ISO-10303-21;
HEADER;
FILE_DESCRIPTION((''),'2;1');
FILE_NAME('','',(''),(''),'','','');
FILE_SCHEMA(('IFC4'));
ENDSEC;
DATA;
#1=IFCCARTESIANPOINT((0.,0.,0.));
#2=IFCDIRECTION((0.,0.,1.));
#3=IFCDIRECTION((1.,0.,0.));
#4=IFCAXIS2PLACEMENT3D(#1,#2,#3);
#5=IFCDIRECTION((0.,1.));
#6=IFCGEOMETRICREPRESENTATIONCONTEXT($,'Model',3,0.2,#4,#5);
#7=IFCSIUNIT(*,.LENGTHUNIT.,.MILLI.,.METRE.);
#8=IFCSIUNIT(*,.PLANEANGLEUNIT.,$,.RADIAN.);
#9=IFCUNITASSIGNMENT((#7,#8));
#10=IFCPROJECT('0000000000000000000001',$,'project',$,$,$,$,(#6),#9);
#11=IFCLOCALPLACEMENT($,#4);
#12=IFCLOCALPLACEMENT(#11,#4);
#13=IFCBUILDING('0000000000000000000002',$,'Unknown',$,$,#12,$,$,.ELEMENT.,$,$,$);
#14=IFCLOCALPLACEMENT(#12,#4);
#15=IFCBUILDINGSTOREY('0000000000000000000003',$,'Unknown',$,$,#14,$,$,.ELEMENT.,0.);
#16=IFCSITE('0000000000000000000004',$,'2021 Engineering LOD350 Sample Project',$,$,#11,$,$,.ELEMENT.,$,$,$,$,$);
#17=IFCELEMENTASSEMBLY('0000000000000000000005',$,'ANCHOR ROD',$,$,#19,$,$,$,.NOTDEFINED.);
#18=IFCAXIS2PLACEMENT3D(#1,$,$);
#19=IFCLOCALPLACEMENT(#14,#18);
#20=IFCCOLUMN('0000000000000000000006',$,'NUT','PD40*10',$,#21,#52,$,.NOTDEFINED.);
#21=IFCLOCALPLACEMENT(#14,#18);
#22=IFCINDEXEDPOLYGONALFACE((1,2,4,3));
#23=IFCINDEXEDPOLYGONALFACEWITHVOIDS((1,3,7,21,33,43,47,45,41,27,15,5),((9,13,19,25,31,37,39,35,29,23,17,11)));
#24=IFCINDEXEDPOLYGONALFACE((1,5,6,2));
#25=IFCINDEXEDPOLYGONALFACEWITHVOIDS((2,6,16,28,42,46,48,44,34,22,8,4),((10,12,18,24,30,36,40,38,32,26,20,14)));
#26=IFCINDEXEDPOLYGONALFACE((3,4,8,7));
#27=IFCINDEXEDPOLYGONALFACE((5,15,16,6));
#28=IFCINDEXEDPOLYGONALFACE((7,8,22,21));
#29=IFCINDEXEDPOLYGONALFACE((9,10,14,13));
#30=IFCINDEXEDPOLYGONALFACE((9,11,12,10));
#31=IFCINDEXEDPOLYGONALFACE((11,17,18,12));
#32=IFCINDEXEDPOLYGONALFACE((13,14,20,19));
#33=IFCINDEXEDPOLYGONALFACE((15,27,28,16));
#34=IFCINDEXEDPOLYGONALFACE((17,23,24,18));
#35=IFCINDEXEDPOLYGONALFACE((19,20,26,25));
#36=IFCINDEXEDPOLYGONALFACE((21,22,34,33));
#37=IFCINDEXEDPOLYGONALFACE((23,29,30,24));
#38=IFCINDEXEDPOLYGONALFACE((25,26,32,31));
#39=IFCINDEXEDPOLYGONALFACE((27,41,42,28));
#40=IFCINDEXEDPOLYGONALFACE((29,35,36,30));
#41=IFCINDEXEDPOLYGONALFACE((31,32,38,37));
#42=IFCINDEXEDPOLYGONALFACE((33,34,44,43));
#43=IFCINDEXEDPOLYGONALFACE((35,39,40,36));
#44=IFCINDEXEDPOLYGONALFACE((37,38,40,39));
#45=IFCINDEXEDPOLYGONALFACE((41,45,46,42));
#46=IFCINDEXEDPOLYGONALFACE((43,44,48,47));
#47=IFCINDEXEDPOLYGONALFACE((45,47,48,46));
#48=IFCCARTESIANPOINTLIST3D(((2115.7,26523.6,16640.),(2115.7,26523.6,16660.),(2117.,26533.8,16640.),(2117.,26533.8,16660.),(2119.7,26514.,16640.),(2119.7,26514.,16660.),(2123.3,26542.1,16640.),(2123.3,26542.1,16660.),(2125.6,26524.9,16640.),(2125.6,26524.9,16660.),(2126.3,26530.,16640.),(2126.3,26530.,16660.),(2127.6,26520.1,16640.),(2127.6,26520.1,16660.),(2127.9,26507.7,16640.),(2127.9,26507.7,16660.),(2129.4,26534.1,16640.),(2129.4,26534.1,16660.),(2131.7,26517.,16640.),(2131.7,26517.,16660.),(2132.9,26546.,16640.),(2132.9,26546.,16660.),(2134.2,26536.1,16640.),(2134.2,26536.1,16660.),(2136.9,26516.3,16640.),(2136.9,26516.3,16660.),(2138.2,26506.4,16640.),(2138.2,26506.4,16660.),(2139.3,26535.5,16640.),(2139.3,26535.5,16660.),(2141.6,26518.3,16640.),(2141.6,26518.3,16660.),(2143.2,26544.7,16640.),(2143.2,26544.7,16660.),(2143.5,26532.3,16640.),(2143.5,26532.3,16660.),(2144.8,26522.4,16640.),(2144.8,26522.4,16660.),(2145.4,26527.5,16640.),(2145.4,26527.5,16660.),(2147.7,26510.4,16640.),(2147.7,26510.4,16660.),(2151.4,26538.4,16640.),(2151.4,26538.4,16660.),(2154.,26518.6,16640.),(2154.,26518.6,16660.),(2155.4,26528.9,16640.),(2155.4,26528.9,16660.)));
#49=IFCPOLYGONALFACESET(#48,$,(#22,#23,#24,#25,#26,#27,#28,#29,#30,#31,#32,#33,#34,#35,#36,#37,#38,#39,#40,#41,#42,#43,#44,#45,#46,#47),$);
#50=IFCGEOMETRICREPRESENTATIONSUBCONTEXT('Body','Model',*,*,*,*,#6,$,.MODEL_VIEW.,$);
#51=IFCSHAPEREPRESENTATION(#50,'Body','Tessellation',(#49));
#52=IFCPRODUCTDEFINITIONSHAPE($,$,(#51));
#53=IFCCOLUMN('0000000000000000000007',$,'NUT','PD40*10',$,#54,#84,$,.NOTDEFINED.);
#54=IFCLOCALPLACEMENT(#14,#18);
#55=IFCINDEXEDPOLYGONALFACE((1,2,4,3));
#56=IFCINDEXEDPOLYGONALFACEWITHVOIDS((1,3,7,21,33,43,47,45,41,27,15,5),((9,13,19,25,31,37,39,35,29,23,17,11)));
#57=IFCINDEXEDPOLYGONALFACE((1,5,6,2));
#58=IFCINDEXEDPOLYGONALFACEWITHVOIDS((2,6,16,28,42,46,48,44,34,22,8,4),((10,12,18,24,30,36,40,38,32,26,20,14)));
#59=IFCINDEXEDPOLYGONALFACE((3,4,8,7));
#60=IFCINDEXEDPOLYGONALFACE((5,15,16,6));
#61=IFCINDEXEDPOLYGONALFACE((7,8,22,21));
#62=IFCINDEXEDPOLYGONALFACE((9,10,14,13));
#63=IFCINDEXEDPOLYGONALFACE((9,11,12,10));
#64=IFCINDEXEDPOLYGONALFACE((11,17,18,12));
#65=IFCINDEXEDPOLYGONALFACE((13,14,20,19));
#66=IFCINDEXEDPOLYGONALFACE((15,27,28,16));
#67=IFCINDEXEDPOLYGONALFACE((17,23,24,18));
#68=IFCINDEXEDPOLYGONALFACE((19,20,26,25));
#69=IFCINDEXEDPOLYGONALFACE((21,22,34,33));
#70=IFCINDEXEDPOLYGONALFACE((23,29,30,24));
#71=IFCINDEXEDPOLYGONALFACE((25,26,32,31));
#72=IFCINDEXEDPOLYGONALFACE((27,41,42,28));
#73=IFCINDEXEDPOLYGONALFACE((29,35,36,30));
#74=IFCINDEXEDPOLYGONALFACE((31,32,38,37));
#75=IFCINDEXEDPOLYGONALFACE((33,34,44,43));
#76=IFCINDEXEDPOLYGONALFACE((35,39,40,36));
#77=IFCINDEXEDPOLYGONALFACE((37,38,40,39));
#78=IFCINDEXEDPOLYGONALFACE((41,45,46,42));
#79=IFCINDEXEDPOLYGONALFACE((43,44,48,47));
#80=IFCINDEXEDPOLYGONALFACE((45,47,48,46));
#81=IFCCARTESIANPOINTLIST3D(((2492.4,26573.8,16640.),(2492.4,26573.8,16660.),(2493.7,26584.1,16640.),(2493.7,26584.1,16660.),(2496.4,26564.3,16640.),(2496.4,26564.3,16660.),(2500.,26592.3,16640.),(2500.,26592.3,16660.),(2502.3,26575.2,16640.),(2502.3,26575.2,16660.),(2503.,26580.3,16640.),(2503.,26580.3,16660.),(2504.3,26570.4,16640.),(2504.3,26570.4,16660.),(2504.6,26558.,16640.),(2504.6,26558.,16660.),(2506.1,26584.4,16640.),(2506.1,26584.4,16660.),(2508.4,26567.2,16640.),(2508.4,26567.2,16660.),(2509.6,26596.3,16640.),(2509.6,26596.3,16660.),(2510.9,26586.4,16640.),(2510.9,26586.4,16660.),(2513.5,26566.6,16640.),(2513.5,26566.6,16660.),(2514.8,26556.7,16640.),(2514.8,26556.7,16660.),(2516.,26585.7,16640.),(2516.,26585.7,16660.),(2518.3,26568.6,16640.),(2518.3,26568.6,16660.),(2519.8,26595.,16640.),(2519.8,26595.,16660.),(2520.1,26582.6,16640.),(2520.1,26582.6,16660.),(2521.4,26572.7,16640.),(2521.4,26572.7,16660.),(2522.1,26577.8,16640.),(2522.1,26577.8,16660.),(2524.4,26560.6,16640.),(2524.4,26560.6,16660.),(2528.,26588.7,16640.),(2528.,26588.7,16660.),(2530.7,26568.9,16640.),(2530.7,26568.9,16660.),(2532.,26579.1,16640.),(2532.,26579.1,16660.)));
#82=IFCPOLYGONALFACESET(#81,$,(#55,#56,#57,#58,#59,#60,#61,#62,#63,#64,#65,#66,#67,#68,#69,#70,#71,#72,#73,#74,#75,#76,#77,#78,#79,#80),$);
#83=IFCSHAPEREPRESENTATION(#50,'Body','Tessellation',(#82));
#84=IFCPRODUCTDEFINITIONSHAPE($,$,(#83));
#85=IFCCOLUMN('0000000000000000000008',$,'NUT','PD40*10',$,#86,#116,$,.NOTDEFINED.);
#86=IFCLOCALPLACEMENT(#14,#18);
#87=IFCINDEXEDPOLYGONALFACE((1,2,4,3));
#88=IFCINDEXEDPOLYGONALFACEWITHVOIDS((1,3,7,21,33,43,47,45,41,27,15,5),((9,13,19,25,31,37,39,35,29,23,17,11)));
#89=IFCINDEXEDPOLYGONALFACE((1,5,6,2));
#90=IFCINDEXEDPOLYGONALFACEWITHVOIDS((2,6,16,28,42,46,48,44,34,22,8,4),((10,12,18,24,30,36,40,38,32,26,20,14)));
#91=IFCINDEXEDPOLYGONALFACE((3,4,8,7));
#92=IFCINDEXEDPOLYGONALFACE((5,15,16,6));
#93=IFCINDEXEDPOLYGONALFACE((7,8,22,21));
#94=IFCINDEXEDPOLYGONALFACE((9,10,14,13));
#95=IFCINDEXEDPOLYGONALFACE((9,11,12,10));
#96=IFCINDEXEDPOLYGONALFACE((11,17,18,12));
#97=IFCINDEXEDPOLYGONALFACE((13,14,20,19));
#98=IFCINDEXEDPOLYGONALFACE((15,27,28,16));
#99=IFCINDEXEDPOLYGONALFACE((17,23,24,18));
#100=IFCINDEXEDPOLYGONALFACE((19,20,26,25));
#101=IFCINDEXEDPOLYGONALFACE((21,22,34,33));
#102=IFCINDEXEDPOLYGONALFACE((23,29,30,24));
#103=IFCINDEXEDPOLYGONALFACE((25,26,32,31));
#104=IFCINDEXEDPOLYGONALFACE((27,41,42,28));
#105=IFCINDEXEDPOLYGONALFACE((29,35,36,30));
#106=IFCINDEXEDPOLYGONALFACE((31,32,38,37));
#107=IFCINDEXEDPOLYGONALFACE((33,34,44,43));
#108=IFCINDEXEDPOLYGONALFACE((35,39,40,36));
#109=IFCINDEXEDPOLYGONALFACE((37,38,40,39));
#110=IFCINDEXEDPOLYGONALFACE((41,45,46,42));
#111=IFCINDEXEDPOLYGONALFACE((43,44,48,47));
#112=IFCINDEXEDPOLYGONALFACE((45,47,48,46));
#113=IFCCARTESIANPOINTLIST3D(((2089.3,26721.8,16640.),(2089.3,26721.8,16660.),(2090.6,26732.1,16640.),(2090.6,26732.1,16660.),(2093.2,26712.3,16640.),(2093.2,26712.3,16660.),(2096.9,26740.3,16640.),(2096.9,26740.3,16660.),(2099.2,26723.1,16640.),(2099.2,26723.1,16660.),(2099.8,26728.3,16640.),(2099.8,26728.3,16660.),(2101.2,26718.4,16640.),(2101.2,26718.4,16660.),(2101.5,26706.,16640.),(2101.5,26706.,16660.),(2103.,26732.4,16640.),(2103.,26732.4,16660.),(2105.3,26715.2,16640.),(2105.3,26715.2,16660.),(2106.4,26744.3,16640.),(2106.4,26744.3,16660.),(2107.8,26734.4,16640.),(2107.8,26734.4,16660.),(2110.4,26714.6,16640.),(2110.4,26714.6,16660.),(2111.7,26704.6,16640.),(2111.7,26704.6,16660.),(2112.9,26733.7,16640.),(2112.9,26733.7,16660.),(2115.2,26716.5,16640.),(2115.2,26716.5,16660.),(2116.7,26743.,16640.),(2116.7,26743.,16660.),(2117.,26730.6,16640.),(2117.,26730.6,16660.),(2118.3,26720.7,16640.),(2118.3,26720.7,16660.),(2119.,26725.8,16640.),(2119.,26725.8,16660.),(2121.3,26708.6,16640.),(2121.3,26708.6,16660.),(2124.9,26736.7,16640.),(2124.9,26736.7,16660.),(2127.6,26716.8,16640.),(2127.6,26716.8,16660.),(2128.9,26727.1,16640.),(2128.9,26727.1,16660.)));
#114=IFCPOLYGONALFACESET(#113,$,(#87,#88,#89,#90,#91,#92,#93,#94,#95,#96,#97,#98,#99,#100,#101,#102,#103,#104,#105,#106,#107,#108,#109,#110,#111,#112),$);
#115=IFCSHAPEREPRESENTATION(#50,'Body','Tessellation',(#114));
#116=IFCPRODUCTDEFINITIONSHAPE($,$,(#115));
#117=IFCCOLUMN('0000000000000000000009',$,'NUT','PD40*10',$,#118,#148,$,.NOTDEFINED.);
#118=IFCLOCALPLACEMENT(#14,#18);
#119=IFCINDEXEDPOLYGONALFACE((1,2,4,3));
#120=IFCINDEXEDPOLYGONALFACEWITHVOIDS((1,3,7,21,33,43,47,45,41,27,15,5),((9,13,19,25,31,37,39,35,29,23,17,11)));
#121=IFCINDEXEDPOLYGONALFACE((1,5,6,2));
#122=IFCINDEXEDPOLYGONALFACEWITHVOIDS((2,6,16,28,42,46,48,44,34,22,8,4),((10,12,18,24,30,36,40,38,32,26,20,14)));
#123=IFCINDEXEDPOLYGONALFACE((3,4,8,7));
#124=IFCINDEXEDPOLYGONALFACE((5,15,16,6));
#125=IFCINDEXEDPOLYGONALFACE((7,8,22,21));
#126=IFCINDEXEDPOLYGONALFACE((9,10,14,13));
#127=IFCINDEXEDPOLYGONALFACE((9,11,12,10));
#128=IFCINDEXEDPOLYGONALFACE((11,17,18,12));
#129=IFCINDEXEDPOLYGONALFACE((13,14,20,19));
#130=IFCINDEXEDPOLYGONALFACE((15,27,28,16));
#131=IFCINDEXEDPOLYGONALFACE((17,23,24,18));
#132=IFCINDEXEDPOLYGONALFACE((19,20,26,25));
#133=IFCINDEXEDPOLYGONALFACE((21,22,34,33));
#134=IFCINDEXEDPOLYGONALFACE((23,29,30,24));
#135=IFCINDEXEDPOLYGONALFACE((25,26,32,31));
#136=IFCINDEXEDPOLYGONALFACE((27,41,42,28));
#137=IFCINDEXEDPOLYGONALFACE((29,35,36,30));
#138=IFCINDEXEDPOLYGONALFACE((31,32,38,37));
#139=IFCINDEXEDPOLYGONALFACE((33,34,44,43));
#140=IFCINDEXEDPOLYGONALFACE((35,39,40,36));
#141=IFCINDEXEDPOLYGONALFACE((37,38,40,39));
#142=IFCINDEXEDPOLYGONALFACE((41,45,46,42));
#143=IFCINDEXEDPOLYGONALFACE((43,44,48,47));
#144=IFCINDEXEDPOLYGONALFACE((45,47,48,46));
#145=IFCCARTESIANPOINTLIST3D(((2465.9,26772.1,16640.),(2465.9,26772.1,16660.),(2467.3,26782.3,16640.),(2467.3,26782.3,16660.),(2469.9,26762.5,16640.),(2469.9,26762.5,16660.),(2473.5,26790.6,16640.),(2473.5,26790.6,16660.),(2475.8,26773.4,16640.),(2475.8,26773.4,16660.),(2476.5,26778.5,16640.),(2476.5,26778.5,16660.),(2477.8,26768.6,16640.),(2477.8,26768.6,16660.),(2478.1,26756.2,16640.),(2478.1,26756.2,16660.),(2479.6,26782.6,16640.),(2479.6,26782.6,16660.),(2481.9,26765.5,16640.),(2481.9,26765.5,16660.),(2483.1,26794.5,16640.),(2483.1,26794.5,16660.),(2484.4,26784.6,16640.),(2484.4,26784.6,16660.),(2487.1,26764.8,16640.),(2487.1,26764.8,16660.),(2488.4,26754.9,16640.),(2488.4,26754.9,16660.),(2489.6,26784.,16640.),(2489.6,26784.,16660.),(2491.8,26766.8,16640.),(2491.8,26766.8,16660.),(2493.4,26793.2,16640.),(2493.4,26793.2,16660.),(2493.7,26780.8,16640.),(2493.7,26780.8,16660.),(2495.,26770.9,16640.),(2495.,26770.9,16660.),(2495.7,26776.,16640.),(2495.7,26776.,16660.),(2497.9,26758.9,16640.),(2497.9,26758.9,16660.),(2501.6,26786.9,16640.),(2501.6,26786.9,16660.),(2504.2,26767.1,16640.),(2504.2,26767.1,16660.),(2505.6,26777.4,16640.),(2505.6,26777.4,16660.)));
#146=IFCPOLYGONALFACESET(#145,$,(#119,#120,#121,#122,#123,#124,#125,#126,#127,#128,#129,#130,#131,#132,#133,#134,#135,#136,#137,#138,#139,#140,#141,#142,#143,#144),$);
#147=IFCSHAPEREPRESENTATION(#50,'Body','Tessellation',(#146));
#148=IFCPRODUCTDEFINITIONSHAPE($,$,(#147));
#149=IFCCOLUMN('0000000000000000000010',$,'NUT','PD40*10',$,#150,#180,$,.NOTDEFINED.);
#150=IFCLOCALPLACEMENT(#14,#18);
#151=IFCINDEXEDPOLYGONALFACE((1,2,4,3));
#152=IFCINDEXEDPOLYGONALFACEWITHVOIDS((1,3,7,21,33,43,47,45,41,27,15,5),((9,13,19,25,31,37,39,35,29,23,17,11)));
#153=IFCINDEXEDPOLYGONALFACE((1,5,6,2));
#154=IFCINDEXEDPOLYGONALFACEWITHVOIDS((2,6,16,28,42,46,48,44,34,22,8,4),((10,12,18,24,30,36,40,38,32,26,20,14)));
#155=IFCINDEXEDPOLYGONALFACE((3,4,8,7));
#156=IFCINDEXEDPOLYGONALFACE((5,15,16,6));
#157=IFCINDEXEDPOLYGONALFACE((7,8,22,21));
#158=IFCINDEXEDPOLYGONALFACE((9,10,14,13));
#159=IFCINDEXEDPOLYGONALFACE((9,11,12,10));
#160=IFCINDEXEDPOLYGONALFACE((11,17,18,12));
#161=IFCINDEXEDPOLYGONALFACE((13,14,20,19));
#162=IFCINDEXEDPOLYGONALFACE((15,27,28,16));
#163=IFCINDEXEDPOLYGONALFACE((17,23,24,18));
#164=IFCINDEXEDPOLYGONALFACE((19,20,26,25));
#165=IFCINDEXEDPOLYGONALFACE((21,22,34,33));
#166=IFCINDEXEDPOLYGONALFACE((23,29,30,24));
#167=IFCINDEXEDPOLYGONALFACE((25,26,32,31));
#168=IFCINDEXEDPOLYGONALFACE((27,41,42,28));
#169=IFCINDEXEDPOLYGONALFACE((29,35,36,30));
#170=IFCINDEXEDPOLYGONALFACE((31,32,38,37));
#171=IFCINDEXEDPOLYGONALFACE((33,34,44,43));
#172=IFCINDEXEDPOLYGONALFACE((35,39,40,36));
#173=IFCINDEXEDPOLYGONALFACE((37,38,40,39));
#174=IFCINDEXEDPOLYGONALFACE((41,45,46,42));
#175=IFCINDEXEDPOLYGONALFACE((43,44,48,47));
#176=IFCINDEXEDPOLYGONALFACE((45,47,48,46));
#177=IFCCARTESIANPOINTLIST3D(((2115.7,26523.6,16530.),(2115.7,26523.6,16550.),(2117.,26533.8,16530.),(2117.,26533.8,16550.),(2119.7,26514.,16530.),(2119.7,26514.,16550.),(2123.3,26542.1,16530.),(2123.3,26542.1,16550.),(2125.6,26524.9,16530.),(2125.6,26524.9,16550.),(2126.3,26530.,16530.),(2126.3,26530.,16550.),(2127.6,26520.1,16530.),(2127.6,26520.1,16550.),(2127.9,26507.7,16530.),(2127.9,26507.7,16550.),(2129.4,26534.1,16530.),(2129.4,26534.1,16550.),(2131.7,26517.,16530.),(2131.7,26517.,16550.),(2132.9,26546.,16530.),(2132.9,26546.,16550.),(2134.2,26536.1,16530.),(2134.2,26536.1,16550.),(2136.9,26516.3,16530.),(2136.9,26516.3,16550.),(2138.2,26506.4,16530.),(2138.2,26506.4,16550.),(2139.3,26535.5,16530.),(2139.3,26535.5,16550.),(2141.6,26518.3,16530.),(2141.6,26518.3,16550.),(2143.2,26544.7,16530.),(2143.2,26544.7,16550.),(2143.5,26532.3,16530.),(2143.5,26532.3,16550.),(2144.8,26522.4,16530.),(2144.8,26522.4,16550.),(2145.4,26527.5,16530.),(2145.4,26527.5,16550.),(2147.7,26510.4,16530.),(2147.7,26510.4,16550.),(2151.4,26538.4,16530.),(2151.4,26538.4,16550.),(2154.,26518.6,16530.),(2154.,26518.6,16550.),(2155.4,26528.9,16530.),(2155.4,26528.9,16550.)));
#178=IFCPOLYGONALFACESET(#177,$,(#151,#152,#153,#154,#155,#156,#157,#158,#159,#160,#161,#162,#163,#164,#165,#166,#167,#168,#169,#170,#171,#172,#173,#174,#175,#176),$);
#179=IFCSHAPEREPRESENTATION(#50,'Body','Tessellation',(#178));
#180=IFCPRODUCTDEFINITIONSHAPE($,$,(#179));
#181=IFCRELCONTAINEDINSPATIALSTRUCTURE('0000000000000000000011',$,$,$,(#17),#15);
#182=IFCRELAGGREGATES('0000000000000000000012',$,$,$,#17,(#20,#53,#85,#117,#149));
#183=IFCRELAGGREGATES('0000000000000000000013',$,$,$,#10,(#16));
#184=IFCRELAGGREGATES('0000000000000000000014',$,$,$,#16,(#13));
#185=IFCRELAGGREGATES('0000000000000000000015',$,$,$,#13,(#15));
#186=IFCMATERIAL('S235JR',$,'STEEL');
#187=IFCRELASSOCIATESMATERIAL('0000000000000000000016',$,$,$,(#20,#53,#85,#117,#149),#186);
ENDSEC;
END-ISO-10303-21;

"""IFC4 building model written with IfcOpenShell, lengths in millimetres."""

from ifc_helpers import new_model, si_unit, direction, frame, origin_with_axes, place, context, subcontext, project, spatial, line, indexed_curve, outline, extrude, material, element, aggregate, save


model = new_model("IFC4")

# Units and contexts
model_context = context("Model", 3, precision=0.2, world=origin_with_axes(), true_north=direction((0.0, 1.0)))
body_context = subcontext(model_context, "Body", "Model", "MODEL_VIEW")
ifc_project = project(units=[si_unit("LENGTHUNIT", "METRE", prefix="MILLI"), si_unit("PLANEANGLEUNIT", "RADIAN")], contexts=[model_context])

# Site, building, storey
site_placement = place(None, origin_with_axes())
site = spatial("IfcSite", under=ifc_project, at=site_placement, Name="2021 Engineering LOD350 Sample Project", CompositionType="ELEMENT")
building_placement = place(site_placement, origin_with_axes())
building = spatial("IfcBuilding", under=site, at=building_placement, Name="Unknown", CompositionType="ELEMENT")
storey_placement = place(building_placement, origin_with_axes())
storey = spatial("IfcBuildingStorey", under=building, at=storey_placement, Name="Unknown", CompositionType="ELEMENT", Elevation=0.0)

# Element assembly, columns
assembly_1_placement = place(storey_placement, frame((2485.7, 26774.7, 16730.0), z_axis=(0.991216, 0.132256, 0.0), x_axis=(0.0, 0.0, -1.0)))
assembly_1 = element("IfcElementAssembly", 1, at=assembly_1_placement, inside=storey, Name="ANCHOR ROD", PredefinedType="NOTDEFINED")
ifc_material_1 = material(Name="S235JR", Category="STEEL")
column_1_placement = place(assembly_1_placement, frame((70.0, -200.0, -380.0), z_axis=(0.0, 0.0, -1.0), x_axis=(1.0, 0.0, 0.0)))
column_1 = element("IfcColumn", 2, at=column_1_placement, material=ifc_material_1, Name="NUT", Description="PD40*10", PredefinedType="NOTDEFINED", context=body_context, shape_type="SolidModel", body=[
    extrude(outline(indexed_curve([(20.0, 0.0), (17.3, 10.0), (10.0, 17.3), (0.0, 20.0), (-10.0, 17.3), (-17.3, 10.0), (-20.0, 0.0), (-17.3, -10.0), (-10.0, -17.3), (0.0, -20.0), (10.0, -17.3), (17.3, -10.0)], segments=[line(1, 2, 3, 4, 5, 6, 7, 8, 9, 10, 11, 12, 1)]), holes=[indexed_curve([(10.0, 0.0), (8.7, -5.0), (5.0, -8.7), (0.0, -10.0), (-5.0, -8.7), (-8.7, -5.0), (-10.0, 0.0), (-8.7, 5.0), (-5.0, 8.7), (0.0, 10.0), (5.0, 8.7), (8.7, 5.0)], segments=[line(1, 2, 3, 4, 5, 6, 7, 8, 9, 10, 11, 12, 1)])]), frame((0.0, 0.0, 0.0), z_axis=(-1.0, 0.0, 0.0), x_axis=(0.0, 0.0, 1.0)), (0.0, 0.0, -1.0), 20.0),
])
column_2_placement = place(assembly_1_placement, frame((70.0, -200.0, 0.0), z_axis=(0.0, 0.0, 1.0), x_axis=(1.0, 0.0, 0.0)))
column_2 = element("IfcColumn", 3, at=column_2_placement, material=ifc_material_1, Name="NUT", Description="PD40*10", PredefinedType="NOTDEFINED", context=body_context, shape_type="SolidModel", body=[
    extrude(outline(indexed_curve([(20.0, 0.0), (17.3, 10.0), (10.0, 17.3), (0.0, 20.0), (-10.0, 17.3), (-17.3, 10.0), (-20.0, 0.0), (-17.3, -10.0), (-10.0, -17.3), (0.0, -20.0), (10.0, -17.3), (17.3, -10.0)], segments=[line(1, 2, 3, 4, 5, 6, 7, 8, 9, 10, 11, 12, 1)]), holes=[indexed_curve([(10.0, 0.0), (8.7, -5.0), (5.0, -8.7), (0.0, -10.0), (-5.0, -8.7), (-8.7, -5.0), (-10.0, 0.0), (-8.7, 5.0), (-5.0, 8.7), (0.0, 10.0), (5.0, 8.7), (8.7, 5.0)], segments=[line(1, 2, 3, 4, 5, 6, 7, 8, 9, 10, 11, 12, 1)])]), frame((0.0, 0.0, 0.0), z_axis=(-1.0, 0.0, 0.0), x_axis=(0.0, 0.0, 1.0)), (0.0, 0.0, -1.0), 20.0),
])
column_3_placement = place(assembly_1_placement, frame((70.0, 0.0, -380.0), z_axis=(0.0, 0.0, -1.0), x_axis=(1.0, 0.0, 0.0)))
column_3 = element("IfcColumn", 4, at=column_3_placement, material=ifc_material_1, Name="NUT", Description="PD40*10", PredefinedType="NOTDEFINED", context=body_context, shape_type="SolidModel", body=[
    extrude(outline(indexed_curve([(20.0, 0.0), (17.3, 10.0), (10.0, 17.3), (0.0, 20.0), (-10.0, 17.3), (-17.3, 10.0), (-20.0, 0.0), (-17.3, -10.0), (-10.0, -17.3), (0.0, -20.0), (10.0, -17.3), (17.3, -10.0)], segments=[line(1, 2, 3, 4, 5, 6, 7, 8, 9, 10, 11, 12, 1)]), holes=[indexed_curve([(10.0, 0.0), (8.7, -5.0), (5.0, -8.7), (0.0, -10.0), (-5.0, -8.7), (-8.7, -5.0), (-10.0, 0.0), (-8.7, 5.0), (-5.0, 8.7), (0.0, 10.0), (5.0, 8.7), (8.7, 5.0)], segments=[line(1, 2, 3, 4, 5, 6, 7, 8, 9, 10, 11, 12, 1)])]), frame((0.0, 0.0, 0.0), z_axis=(-1.0, 0.0, 0.0), x_axis=(0.0, 0.0, 1.0)), (0.0, 0.0, -1.0), 20.0),
])
column_4_placement = place(assembly_1_placement, frame((70.0, 0.0, 0.0), z_axis=(0.0, 0.0, 1.0), x_axis=(1.0, 0.0, 0.0)))
column_4 = element("IfcColumn", 5, at=column_4_placement, material=ifc_material_1, Name="NUT", Description="PD40*10", PredefinedType="NOTDEFINED", context=body_context, shape_type="SolidModel", body=[
    extrude(outline(indexed_curve([(20.0, 0.0), (17.3, 10.0), (10.0, 17.3), (0.0, 20.0), (-10.0, 17.3), (-17.3, 10.0), (-20.0, 0.0), (-17.3, -10.0), (-10.0, -17.3), (0.0, -20.0), (10.0, -17.3), (17.3, -10.0)], segments=[line(1, 2, 3, 4, 5, 6, 7, 8, 9, 10, 11, 12, 1)]), holes=[indexed_curve([(10.0, 0.0), (8.7, -5.0), (5.0, -8.7), (0.0, -10.0), (-5.0, -8.7), (-8.7, -5.0), (-10.0, 0.0), (-8.7, 5.0), (-5.0, 8.7), (0.0, 10.0), (5.0, 8.7), (8.7, 5.0)], segments=[line(1, 2, 3, 4, 5, 6, 7, 8, 9, 10, 11, 12, 1)])]), frame((0.0, 0.0, 0.0), z_axis=(-1.0, 0.0, 0.0), x_axis=(0.0, 0.0, 1.0)), (0.0, 0.0, -1.0), 20.0),
])
column_5_placement = place(assembly_1_placement, frame((180.0, -200.0, -380.0), z_axis=(0.0, 0.0, -1.0), x_axis=(1.0, 0.0, 0.0)))
column_5 = element("IfcColumn", 6, at=column_5_placement, material=ifc_material_1, Name="NUT", Description="PD40*10", PredefinedType="NOTDEFINED", context=body_context, shape_type="SolidModel", body=[
    extrude(outline(indexed_curve([(20.0, 0.0), (17.3, 10.0), (10.0, 17.3), (0.0, 20.0), (-10.0, 17.3), (-17.3, 10.0), (-20.0, 0.0), (-17.3, -10.0), (-10.0, -17.3), (0.0, -20.0), (10.0, -17.3), (17.3, -10.0)], segments=[line(1, 2, 3, 4, 5, 6, 7, 8, 9, 10, 11, 12, 1)]), holes=[indexed_curve([(10.0, 0.0), (8.7, -5.0), (5.0, -8.7), (0.0, -10.0), (-5.0, -8.7), (-8.7, -5.0), (-10.0, 0.0), (-8.7, 5.0), (-5.0, 8.7), (0.0, 10.0), (5.0, 8.7), (8.7, 5.0)], segments=[line(1, 2, 3, 4, 5, 6, 7, 8, 9, 10, 11, 12, 1)])]), frame((0.0, 0.0, 0.0), z_axis=(-1.0, 0.0, 0.0), x_axis=(0.0, 0.0, 1.0)), (0.0, 0.0, -1.0), 20.0),
])

aggregate(assembly_1, [column_1, column_2, column_3, column_4, column_5])

save(model, "model.ifc")
